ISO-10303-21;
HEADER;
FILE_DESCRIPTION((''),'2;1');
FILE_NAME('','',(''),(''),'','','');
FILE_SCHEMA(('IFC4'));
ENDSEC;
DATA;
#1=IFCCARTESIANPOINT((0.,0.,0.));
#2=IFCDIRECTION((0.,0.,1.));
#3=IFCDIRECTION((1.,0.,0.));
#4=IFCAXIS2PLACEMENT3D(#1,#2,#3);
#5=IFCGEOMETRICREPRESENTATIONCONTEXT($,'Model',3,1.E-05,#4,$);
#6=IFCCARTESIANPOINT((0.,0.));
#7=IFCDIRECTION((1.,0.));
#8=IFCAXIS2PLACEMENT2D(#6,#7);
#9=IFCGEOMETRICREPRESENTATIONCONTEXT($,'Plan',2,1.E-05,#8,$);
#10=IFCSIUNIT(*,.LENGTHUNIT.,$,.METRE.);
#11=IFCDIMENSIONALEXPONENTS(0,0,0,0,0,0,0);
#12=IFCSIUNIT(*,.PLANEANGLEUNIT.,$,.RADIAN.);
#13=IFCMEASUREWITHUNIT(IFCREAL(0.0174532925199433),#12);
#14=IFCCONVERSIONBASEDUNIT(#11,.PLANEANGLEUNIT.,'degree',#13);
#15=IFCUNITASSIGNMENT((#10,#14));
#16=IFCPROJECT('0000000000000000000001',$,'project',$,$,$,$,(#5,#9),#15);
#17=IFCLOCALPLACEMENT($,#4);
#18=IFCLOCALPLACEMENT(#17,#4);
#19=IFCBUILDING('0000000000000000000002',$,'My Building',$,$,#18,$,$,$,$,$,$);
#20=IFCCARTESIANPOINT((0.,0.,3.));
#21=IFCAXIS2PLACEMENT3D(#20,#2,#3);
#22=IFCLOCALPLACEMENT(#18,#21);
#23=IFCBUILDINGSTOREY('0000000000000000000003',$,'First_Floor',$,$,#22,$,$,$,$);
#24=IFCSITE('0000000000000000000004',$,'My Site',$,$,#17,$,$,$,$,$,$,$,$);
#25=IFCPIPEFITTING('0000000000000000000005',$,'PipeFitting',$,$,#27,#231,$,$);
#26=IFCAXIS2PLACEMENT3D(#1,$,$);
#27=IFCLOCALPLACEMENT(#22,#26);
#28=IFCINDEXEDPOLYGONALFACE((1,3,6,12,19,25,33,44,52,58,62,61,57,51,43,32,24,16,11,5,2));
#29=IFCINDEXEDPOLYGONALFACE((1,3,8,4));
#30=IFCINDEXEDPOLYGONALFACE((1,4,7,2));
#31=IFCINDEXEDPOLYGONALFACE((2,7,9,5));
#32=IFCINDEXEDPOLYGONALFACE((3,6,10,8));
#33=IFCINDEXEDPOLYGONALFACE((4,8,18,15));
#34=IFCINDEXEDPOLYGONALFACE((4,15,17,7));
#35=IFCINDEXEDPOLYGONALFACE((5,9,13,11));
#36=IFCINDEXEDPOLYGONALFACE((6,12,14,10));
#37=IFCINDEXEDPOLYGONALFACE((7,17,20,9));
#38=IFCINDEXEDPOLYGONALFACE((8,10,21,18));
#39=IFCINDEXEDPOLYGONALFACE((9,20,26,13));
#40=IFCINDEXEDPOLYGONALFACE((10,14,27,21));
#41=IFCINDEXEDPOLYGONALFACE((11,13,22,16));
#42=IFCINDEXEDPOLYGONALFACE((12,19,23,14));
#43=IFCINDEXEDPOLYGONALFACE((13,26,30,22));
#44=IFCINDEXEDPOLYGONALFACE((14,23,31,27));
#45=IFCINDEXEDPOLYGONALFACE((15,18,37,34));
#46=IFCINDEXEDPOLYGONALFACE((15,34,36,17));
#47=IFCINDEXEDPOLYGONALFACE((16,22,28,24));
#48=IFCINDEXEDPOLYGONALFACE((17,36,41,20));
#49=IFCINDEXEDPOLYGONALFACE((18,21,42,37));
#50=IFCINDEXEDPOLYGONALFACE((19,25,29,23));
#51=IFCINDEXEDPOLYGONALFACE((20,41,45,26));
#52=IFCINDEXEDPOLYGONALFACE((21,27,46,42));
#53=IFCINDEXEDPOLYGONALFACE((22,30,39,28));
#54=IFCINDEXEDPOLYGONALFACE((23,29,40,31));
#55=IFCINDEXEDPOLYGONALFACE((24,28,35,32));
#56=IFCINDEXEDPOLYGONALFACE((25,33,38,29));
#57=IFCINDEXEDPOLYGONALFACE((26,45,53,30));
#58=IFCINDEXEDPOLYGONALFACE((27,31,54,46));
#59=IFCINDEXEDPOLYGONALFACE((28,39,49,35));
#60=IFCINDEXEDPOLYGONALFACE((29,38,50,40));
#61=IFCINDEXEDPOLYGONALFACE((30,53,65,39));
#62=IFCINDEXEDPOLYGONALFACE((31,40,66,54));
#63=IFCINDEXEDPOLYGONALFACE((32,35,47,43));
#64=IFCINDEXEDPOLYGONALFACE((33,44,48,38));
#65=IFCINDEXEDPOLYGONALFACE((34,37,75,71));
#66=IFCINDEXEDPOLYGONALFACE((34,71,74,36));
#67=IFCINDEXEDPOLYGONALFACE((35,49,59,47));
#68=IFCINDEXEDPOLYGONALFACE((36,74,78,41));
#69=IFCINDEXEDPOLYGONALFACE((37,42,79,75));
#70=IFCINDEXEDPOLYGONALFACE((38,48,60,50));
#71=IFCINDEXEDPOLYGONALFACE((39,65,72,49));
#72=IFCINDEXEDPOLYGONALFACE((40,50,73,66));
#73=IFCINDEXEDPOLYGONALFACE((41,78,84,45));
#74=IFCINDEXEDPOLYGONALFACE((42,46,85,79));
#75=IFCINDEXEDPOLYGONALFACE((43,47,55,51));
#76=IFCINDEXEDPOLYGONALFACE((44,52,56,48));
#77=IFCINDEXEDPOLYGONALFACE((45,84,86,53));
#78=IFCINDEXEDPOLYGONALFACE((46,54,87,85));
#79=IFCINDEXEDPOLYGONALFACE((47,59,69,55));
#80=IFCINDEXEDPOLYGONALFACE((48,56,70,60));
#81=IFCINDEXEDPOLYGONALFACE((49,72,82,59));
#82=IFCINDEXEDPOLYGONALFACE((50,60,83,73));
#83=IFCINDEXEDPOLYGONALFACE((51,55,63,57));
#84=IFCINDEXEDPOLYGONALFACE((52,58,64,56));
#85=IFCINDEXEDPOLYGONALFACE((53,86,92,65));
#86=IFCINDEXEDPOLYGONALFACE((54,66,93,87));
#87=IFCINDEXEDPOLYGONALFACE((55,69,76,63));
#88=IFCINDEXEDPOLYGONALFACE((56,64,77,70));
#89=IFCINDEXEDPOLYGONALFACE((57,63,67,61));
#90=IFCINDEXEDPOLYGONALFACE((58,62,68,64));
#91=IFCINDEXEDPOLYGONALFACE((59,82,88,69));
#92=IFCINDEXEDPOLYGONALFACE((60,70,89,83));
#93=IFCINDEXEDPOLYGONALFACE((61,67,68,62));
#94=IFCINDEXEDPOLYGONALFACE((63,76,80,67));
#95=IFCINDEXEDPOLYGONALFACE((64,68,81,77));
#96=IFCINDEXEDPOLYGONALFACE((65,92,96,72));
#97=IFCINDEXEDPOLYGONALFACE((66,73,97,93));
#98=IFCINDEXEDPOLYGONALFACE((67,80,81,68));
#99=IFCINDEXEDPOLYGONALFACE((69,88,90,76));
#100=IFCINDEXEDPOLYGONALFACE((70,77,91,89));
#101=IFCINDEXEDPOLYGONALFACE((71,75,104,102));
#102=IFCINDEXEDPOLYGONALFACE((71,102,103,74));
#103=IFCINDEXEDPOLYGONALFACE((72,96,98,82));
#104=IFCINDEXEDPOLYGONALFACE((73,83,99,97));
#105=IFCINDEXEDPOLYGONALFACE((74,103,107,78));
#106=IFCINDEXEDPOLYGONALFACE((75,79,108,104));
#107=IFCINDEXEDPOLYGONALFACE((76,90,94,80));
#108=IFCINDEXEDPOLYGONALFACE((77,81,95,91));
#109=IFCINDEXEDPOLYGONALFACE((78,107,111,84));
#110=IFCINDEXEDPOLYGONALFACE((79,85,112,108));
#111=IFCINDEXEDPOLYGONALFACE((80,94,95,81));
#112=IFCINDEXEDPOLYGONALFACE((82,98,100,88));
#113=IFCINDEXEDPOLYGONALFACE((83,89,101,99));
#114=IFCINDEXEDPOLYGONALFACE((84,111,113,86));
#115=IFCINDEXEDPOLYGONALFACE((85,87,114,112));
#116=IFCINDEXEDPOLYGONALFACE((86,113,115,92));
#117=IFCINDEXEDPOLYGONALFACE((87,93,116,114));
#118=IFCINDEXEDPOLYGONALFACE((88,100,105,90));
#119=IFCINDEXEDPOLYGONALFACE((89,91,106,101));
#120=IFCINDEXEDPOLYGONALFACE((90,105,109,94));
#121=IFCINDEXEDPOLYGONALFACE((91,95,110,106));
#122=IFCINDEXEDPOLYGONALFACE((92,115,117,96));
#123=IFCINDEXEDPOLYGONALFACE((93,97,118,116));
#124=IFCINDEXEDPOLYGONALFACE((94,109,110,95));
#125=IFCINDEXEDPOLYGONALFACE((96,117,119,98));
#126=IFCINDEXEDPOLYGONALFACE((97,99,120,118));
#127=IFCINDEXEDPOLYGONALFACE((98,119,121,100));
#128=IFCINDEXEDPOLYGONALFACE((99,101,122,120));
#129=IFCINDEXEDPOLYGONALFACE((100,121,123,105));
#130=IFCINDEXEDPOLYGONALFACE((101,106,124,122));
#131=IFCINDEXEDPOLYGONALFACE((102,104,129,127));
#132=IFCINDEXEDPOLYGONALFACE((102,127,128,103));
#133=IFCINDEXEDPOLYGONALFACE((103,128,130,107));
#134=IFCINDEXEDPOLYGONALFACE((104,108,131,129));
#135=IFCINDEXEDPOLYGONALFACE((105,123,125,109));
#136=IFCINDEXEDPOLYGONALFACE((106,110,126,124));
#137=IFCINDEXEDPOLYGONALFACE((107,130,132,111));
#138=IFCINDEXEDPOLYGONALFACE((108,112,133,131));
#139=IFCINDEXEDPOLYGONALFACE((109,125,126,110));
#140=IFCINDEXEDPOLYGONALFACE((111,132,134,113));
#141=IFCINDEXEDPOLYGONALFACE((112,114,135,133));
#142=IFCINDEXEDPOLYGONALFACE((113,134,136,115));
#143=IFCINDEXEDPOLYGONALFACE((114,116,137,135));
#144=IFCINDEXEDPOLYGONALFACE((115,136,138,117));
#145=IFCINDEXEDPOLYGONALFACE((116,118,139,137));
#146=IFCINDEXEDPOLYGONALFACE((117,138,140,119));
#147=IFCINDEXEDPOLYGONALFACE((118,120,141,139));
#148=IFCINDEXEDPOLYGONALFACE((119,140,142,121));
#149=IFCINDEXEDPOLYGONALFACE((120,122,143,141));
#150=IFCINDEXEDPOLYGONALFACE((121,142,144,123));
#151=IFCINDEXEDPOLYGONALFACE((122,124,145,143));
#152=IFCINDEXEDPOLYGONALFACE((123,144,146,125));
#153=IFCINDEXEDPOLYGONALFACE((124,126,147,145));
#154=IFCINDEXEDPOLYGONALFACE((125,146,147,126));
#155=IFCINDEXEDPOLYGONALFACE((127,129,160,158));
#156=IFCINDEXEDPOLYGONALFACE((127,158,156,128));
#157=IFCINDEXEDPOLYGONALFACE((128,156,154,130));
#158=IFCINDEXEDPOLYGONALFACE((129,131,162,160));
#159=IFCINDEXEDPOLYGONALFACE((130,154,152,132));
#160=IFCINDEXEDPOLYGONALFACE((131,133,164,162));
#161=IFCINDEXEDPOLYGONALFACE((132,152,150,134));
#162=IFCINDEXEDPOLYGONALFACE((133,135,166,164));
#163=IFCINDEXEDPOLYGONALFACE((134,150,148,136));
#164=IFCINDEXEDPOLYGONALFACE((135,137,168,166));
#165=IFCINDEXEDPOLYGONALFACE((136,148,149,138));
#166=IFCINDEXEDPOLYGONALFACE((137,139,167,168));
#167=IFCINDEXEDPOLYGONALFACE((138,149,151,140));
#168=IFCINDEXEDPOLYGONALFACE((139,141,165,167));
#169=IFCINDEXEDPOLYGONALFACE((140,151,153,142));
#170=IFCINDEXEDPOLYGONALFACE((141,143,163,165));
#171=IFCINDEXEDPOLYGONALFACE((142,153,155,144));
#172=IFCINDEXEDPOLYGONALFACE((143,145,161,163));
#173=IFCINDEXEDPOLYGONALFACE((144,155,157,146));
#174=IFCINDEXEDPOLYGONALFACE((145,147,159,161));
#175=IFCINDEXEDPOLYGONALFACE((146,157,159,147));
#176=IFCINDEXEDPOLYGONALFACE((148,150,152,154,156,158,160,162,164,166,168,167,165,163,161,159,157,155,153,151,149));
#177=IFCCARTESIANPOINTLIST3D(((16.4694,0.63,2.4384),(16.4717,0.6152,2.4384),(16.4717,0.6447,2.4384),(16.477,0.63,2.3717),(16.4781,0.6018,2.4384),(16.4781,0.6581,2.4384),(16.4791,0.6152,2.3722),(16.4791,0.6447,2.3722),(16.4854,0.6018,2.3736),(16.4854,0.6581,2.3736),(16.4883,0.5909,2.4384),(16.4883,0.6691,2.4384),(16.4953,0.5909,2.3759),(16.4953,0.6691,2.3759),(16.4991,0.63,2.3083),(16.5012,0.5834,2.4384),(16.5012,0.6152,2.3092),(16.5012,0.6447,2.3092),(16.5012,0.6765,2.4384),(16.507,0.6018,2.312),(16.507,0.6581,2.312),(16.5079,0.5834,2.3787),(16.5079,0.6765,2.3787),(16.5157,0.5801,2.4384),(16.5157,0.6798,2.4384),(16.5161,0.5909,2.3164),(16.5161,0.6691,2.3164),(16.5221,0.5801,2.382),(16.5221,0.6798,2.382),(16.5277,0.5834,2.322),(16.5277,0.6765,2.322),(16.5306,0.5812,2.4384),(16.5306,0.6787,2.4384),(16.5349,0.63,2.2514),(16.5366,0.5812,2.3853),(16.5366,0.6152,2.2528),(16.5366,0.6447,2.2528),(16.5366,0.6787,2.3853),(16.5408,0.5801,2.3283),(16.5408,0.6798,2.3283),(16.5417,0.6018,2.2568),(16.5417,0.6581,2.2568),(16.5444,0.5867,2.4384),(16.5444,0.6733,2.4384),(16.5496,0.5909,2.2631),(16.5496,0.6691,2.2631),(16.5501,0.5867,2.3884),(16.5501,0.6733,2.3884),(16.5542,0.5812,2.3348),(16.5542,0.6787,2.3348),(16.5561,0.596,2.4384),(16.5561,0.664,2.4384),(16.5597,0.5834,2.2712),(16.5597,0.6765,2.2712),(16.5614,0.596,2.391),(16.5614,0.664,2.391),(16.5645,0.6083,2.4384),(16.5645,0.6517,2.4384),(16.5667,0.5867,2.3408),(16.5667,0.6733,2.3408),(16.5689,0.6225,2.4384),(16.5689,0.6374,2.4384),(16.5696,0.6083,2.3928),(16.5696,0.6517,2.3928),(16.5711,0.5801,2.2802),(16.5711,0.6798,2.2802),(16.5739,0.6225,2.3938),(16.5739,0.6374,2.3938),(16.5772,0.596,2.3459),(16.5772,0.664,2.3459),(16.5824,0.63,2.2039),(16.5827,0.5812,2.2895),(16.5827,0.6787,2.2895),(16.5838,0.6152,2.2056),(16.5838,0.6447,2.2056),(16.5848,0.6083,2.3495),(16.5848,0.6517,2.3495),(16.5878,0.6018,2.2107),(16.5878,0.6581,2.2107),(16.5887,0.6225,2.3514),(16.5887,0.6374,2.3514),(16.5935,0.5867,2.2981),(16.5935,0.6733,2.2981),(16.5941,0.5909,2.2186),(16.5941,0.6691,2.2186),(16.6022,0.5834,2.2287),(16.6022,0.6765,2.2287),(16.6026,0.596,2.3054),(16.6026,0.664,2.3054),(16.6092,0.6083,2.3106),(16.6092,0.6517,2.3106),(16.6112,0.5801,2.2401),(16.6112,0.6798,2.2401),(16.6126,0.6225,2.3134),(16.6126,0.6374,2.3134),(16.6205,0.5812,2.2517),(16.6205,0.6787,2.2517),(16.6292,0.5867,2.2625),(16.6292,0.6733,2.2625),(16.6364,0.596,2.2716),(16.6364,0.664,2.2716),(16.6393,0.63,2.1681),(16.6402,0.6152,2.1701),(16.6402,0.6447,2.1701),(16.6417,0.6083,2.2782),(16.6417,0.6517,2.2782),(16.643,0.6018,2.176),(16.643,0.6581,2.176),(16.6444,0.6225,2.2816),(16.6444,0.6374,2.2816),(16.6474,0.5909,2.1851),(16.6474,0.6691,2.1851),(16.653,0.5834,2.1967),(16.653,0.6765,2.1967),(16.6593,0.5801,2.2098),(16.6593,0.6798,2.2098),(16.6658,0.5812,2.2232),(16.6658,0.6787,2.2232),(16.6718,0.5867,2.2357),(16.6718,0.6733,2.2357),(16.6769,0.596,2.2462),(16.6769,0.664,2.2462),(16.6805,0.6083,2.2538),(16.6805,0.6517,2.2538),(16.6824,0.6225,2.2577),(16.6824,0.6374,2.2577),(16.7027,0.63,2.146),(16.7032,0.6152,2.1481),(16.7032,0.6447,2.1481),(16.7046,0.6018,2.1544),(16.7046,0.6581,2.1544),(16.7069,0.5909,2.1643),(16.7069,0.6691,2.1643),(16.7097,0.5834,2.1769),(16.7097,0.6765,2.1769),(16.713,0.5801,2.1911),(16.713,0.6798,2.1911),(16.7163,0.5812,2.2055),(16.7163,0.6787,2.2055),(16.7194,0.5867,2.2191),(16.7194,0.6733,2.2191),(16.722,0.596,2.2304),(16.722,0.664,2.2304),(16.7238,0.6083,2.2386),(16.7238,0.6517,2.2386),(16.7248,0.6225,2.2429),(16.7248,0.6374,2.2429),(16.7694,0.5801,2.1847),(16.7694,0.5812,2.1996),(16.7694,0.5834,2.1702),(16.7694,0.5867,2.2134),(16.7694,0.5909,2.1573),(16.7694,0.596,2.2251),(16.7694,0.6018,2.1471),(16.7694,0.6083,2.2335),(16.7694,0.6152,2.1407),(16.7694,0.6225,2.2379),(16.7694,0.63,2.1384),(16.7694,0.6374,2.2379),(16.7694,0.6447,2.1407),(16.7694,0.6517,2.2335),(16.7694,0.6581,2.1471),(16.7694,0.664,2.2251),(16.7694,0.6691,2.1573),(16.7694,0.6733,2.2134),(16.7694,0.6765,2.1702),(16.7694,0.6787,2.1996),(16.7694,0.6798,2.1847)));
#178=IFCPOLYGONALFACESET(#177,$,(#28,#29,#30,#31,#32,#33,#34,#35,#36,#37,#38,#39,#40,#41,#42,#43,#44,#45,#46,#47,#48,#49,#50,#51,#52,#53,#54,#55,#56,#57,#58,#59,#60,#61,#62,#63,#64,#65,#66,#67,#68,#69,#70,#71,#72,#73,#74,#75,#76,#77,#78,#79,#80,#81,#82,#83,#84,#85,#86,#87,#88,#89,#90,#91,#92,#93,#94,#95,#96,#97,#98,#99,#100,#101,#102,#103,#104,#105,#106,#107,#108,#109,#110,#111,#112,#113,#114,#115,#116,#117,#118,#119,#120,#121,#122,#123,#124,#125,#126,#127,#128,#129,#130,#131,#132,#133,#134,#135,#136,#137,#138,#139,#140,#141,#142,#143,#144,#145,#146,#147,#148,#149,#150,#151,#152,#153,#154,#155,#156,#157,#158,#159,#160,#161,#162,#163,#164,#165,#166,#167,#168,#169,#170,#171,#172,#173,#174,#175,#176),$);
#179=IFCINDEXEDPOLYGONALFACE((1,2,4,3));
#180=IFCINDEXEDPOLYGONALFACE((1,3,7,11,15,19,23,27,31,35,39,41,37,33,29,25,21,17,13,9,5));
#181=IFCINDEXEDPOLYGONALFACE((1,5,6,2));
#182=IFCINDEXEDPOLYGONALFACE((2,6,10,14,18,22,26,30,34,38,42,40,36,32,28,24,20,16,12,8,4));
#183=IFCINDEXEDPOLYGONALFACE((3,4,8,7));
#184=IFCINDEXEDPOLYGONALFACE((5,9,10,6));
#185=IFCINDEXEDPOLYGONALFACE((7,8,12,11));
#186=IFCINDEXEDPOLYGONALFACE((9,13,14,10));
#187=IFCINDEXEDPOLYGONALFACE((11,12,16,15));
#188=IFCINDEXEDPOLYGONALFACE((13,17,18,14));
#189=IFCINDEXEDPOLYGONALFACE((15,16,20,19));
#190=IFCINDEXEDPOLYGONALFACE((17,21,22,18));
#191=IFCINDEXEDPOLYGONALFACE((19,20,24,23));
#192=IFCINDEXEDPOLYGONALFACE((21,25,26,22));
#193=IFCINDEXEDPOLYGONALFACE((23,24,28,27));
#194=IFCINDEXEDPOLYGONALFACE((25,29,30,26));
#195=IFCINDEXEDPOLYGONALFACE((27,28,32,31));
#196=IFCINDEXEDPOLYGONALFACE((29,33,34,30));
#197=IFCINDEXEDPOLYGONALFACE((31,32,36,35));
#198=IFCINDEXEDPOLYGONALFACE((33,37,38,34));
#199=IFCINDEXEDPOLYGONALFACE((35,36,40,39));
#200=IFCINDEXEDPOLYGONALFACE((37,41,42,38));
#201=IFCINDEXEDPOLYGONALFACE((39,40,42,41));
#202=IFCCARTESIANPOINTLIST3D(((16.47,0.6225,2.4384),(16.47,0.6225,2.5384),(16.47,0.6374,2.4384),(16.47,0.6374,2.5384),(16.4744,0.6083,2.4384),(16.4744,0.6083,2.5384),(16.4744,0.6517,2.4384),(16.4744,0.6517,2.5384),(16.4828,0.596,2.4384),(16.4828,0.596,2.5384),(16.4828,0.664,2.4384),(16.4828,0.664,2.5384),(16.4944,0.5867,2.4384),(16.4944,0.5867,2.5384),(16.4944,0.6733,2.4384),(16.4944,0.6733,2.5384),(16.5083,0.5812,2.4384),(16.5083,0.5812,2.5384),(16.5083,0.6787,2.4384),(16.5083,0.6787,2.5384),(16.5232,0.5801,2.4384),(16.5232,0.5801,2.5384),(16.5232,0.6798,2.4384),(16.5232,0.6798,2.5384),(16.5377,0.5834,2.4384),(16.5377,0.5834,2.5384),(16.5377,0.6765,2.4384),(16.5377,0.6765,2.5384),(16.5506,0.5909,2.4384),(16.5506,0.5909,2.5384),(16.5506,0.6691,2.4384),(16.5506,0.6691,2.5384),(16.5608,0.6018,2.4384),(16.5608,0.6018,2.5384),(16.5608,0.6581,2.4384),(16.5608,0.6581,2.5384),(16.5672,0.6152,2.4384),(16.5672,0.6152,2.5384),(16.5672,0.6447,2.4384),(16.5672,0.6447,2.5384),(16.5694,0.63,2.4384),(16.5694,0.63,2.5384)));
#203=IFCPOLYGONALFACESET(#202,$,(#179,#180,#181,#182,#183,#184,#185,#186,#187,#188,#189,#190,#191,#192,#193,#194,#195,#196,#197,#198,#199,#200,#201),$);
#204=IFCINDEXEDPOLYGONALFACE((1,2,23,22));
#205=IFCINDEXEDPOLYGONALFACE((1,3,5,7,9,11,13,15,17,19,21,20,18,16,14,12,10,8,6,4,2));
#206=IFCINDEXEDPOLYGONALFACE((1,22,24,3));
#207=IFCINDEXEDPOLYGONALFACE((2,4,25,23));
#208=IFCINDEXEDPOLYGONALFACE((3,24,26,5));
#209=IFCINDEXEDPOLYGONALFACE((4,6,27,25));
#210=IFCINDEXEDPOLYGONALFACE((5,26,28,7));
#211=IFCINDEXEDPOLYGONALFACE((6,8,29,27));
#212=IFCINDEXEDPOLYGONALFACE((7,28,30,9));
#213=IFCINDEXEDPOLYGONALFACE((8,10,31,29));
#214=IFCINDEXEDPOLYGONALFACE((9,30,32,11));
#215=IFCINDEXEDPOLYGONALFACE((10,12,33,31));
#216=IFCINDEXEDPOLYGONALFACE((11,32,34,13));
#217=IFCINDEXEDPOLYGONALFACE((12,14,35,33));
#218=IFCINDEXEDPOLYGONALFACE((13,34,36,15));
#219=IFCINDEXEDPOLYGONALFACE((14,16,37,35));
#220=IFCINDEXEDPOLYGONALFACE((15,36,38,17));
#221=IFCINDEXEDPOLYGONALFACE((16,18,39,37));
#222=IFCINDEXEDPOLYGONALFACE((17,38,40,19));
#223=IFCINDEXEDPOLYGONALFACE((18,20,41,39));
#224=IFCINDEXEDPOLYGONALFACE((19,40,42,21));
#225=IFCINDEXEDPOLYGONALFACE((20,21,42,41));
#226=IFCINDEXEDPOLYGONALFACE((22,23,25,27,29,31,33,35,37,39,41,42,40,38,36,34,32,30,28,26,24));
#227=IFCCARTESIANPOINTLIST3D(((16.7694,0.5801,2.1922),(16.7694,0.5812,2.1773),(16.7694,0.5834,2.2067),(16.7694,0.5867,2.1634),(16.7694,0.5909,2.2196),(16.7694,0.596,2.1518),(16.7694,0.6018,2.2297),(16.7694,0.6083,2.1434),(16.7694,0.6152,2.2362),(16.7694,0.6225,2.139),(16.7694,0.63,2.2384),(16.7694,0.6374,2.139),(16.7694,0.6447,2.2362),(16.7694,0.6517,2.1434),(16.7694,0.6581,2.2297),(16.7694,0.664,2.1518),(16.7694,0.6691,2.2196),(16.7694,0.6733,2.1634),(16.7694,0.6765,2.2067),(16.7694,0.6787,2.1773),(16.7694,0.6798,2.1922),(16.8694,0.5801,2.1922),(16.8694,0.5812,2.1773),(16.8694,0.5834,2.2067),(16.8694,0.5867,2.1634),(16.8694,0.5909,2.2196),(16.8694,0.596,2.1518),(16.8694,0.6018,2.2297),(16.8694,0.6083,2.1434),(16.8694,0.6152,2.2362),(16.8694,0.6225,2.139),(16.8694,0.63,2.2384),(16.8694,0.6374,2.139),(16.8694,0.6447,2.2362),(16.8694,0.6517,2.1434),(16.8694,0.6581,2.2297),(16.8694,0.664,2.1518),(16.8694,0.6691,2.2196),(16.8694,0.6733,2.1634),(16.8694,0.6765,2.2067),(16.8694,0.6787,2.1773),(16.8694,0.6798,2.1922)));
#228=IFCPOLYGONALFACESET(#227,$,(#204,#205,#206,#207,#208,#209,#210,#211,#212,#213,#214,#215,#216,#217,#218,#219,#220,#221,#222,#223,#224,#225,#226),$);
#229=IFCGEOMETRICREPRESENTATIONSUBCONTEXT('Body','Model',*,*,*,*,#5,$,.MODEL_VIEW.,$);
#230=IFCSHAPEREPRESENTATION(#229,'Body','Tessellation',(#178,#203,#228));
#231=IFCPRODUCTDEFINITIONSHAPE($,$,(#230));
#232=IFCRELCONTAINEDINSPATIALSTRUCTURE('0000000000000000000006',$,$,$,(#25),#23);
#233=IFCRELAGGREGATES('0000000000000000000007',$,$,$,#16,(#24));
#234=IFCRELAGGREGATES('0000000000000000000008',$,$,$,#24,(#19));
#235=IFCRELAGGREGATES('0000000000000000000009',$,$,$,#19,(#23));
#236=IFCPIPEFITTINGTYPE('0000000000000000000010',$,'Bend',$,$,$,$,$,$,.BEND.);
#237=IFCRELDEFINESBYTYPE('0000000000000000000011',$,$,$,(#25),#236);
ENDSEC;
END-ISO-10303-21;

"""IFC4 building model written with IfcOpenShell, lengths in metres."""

from ifc_helpers import new_model, entity, si_unit, converted_unit, frame, origin_with_axes, origin_2d_with_axis, place, context, subcontext, project, spatial, circle, extrude, source, transform, mapped, type_object, type_shapes, element, save


model = new_model("IFC4")

# Units and contexts
model_context = context("Model", 3, precision=1e-05, world=origin_with_axes())
plan_context = context("Plan", 2, precision=1e-05, world=origin_2d_with_axis())
body_context = subcontext(model_context, "Body", "Model", "MODEL_VIEW")
ifc_project = project(units=[si_unit("LENGTHUNIT", "METRE"), converted_unit("PLANEANGLEUNIT", "degree", entity("IfcReal", 0.0174532925199433), si_unit("PLANEANGLEUNIT", "RADIAN"), dimensions=[0, 0, 0, 0, 0, 0, 0])], contexts=[model_context, plan_context])

# Site, building, storey
site_placement = place(None, origin_with_axes())
site = spatial("IfcSite", under=ifc_project, at=site_placement, Name="My Site")
building_placement = place(site_placement, origin_with_axes())
building = spatial("IfcBuilding", under=site, at=building_placement, Name="My Building")
storey_placement = place(building_placement, frame((0.0, 0.0, 3.0), z_axis=(0.0, 0.0, 1.0), x_axis=(1.0, 0.0, 0.0)))
storey = spatial("IfcBuildingStorey", under=building, at=storey_placement, Name="First_Floor")

# Pipe fitting
pipe_fitting_type = type_object("IfcPipeFittingType", Name="Bend", PredefinedType="BEND")
shared_shape = source(origin_with_axes(), body_context, "Body", "SolidModel", [
    entity("IfcSweptDiskSolid", entity("IfcIndexedPolyCurve", entity("IfcCartesianPointList3D", [[0.0, 0.0, -0.1], [0.0732, 0.0, -0.2768], [0.25, 0.0, -0.35]]), [entity("IfcArcIndex", [1, 2, 3])]), 0.05),
    extrude(circle(Radius=0.05), origin_with_axes(), (0.0, 0.0, -1.0), 0.1),
    extrude(circle(Radius=0.05), frame((0.25, 0.0, -0.35), z_axis=(1.0, 0.0, 0.0), x_axis=(0.0, 0.0, 1.0)), (0.0, 0.0, 1.0), 0.1),
])
type_shapes(pipe_fitting_type, [shared_shape])
for number, where, z_axis, x_axis, name in (
    (1, (16.5194, 0.63, 2.5384), (0.0, 0.0, 1.0), (1.0, 0.0, 0.0), "PipeFitting"),
):
    element("IfcPipeFitting", number, at=place(storey_placement, frame(where, z_axis=z_axis, x_axis=x_axis)), inside=storey, type_object=pipe_fitting_type, Name=name, context=body_context, shape_type="MappedRepresentation", body=[
        mapped(shared_shape, transform((0.0, 0.0, 0.0), x_axis=(1.0, 0.0, 0.0), y_axis=(0.0, 1.0, 0.0), z_axis=(0.0, 0.0, 1.0), scale=1.0)),
    ])

save(model, "model.ifc")
